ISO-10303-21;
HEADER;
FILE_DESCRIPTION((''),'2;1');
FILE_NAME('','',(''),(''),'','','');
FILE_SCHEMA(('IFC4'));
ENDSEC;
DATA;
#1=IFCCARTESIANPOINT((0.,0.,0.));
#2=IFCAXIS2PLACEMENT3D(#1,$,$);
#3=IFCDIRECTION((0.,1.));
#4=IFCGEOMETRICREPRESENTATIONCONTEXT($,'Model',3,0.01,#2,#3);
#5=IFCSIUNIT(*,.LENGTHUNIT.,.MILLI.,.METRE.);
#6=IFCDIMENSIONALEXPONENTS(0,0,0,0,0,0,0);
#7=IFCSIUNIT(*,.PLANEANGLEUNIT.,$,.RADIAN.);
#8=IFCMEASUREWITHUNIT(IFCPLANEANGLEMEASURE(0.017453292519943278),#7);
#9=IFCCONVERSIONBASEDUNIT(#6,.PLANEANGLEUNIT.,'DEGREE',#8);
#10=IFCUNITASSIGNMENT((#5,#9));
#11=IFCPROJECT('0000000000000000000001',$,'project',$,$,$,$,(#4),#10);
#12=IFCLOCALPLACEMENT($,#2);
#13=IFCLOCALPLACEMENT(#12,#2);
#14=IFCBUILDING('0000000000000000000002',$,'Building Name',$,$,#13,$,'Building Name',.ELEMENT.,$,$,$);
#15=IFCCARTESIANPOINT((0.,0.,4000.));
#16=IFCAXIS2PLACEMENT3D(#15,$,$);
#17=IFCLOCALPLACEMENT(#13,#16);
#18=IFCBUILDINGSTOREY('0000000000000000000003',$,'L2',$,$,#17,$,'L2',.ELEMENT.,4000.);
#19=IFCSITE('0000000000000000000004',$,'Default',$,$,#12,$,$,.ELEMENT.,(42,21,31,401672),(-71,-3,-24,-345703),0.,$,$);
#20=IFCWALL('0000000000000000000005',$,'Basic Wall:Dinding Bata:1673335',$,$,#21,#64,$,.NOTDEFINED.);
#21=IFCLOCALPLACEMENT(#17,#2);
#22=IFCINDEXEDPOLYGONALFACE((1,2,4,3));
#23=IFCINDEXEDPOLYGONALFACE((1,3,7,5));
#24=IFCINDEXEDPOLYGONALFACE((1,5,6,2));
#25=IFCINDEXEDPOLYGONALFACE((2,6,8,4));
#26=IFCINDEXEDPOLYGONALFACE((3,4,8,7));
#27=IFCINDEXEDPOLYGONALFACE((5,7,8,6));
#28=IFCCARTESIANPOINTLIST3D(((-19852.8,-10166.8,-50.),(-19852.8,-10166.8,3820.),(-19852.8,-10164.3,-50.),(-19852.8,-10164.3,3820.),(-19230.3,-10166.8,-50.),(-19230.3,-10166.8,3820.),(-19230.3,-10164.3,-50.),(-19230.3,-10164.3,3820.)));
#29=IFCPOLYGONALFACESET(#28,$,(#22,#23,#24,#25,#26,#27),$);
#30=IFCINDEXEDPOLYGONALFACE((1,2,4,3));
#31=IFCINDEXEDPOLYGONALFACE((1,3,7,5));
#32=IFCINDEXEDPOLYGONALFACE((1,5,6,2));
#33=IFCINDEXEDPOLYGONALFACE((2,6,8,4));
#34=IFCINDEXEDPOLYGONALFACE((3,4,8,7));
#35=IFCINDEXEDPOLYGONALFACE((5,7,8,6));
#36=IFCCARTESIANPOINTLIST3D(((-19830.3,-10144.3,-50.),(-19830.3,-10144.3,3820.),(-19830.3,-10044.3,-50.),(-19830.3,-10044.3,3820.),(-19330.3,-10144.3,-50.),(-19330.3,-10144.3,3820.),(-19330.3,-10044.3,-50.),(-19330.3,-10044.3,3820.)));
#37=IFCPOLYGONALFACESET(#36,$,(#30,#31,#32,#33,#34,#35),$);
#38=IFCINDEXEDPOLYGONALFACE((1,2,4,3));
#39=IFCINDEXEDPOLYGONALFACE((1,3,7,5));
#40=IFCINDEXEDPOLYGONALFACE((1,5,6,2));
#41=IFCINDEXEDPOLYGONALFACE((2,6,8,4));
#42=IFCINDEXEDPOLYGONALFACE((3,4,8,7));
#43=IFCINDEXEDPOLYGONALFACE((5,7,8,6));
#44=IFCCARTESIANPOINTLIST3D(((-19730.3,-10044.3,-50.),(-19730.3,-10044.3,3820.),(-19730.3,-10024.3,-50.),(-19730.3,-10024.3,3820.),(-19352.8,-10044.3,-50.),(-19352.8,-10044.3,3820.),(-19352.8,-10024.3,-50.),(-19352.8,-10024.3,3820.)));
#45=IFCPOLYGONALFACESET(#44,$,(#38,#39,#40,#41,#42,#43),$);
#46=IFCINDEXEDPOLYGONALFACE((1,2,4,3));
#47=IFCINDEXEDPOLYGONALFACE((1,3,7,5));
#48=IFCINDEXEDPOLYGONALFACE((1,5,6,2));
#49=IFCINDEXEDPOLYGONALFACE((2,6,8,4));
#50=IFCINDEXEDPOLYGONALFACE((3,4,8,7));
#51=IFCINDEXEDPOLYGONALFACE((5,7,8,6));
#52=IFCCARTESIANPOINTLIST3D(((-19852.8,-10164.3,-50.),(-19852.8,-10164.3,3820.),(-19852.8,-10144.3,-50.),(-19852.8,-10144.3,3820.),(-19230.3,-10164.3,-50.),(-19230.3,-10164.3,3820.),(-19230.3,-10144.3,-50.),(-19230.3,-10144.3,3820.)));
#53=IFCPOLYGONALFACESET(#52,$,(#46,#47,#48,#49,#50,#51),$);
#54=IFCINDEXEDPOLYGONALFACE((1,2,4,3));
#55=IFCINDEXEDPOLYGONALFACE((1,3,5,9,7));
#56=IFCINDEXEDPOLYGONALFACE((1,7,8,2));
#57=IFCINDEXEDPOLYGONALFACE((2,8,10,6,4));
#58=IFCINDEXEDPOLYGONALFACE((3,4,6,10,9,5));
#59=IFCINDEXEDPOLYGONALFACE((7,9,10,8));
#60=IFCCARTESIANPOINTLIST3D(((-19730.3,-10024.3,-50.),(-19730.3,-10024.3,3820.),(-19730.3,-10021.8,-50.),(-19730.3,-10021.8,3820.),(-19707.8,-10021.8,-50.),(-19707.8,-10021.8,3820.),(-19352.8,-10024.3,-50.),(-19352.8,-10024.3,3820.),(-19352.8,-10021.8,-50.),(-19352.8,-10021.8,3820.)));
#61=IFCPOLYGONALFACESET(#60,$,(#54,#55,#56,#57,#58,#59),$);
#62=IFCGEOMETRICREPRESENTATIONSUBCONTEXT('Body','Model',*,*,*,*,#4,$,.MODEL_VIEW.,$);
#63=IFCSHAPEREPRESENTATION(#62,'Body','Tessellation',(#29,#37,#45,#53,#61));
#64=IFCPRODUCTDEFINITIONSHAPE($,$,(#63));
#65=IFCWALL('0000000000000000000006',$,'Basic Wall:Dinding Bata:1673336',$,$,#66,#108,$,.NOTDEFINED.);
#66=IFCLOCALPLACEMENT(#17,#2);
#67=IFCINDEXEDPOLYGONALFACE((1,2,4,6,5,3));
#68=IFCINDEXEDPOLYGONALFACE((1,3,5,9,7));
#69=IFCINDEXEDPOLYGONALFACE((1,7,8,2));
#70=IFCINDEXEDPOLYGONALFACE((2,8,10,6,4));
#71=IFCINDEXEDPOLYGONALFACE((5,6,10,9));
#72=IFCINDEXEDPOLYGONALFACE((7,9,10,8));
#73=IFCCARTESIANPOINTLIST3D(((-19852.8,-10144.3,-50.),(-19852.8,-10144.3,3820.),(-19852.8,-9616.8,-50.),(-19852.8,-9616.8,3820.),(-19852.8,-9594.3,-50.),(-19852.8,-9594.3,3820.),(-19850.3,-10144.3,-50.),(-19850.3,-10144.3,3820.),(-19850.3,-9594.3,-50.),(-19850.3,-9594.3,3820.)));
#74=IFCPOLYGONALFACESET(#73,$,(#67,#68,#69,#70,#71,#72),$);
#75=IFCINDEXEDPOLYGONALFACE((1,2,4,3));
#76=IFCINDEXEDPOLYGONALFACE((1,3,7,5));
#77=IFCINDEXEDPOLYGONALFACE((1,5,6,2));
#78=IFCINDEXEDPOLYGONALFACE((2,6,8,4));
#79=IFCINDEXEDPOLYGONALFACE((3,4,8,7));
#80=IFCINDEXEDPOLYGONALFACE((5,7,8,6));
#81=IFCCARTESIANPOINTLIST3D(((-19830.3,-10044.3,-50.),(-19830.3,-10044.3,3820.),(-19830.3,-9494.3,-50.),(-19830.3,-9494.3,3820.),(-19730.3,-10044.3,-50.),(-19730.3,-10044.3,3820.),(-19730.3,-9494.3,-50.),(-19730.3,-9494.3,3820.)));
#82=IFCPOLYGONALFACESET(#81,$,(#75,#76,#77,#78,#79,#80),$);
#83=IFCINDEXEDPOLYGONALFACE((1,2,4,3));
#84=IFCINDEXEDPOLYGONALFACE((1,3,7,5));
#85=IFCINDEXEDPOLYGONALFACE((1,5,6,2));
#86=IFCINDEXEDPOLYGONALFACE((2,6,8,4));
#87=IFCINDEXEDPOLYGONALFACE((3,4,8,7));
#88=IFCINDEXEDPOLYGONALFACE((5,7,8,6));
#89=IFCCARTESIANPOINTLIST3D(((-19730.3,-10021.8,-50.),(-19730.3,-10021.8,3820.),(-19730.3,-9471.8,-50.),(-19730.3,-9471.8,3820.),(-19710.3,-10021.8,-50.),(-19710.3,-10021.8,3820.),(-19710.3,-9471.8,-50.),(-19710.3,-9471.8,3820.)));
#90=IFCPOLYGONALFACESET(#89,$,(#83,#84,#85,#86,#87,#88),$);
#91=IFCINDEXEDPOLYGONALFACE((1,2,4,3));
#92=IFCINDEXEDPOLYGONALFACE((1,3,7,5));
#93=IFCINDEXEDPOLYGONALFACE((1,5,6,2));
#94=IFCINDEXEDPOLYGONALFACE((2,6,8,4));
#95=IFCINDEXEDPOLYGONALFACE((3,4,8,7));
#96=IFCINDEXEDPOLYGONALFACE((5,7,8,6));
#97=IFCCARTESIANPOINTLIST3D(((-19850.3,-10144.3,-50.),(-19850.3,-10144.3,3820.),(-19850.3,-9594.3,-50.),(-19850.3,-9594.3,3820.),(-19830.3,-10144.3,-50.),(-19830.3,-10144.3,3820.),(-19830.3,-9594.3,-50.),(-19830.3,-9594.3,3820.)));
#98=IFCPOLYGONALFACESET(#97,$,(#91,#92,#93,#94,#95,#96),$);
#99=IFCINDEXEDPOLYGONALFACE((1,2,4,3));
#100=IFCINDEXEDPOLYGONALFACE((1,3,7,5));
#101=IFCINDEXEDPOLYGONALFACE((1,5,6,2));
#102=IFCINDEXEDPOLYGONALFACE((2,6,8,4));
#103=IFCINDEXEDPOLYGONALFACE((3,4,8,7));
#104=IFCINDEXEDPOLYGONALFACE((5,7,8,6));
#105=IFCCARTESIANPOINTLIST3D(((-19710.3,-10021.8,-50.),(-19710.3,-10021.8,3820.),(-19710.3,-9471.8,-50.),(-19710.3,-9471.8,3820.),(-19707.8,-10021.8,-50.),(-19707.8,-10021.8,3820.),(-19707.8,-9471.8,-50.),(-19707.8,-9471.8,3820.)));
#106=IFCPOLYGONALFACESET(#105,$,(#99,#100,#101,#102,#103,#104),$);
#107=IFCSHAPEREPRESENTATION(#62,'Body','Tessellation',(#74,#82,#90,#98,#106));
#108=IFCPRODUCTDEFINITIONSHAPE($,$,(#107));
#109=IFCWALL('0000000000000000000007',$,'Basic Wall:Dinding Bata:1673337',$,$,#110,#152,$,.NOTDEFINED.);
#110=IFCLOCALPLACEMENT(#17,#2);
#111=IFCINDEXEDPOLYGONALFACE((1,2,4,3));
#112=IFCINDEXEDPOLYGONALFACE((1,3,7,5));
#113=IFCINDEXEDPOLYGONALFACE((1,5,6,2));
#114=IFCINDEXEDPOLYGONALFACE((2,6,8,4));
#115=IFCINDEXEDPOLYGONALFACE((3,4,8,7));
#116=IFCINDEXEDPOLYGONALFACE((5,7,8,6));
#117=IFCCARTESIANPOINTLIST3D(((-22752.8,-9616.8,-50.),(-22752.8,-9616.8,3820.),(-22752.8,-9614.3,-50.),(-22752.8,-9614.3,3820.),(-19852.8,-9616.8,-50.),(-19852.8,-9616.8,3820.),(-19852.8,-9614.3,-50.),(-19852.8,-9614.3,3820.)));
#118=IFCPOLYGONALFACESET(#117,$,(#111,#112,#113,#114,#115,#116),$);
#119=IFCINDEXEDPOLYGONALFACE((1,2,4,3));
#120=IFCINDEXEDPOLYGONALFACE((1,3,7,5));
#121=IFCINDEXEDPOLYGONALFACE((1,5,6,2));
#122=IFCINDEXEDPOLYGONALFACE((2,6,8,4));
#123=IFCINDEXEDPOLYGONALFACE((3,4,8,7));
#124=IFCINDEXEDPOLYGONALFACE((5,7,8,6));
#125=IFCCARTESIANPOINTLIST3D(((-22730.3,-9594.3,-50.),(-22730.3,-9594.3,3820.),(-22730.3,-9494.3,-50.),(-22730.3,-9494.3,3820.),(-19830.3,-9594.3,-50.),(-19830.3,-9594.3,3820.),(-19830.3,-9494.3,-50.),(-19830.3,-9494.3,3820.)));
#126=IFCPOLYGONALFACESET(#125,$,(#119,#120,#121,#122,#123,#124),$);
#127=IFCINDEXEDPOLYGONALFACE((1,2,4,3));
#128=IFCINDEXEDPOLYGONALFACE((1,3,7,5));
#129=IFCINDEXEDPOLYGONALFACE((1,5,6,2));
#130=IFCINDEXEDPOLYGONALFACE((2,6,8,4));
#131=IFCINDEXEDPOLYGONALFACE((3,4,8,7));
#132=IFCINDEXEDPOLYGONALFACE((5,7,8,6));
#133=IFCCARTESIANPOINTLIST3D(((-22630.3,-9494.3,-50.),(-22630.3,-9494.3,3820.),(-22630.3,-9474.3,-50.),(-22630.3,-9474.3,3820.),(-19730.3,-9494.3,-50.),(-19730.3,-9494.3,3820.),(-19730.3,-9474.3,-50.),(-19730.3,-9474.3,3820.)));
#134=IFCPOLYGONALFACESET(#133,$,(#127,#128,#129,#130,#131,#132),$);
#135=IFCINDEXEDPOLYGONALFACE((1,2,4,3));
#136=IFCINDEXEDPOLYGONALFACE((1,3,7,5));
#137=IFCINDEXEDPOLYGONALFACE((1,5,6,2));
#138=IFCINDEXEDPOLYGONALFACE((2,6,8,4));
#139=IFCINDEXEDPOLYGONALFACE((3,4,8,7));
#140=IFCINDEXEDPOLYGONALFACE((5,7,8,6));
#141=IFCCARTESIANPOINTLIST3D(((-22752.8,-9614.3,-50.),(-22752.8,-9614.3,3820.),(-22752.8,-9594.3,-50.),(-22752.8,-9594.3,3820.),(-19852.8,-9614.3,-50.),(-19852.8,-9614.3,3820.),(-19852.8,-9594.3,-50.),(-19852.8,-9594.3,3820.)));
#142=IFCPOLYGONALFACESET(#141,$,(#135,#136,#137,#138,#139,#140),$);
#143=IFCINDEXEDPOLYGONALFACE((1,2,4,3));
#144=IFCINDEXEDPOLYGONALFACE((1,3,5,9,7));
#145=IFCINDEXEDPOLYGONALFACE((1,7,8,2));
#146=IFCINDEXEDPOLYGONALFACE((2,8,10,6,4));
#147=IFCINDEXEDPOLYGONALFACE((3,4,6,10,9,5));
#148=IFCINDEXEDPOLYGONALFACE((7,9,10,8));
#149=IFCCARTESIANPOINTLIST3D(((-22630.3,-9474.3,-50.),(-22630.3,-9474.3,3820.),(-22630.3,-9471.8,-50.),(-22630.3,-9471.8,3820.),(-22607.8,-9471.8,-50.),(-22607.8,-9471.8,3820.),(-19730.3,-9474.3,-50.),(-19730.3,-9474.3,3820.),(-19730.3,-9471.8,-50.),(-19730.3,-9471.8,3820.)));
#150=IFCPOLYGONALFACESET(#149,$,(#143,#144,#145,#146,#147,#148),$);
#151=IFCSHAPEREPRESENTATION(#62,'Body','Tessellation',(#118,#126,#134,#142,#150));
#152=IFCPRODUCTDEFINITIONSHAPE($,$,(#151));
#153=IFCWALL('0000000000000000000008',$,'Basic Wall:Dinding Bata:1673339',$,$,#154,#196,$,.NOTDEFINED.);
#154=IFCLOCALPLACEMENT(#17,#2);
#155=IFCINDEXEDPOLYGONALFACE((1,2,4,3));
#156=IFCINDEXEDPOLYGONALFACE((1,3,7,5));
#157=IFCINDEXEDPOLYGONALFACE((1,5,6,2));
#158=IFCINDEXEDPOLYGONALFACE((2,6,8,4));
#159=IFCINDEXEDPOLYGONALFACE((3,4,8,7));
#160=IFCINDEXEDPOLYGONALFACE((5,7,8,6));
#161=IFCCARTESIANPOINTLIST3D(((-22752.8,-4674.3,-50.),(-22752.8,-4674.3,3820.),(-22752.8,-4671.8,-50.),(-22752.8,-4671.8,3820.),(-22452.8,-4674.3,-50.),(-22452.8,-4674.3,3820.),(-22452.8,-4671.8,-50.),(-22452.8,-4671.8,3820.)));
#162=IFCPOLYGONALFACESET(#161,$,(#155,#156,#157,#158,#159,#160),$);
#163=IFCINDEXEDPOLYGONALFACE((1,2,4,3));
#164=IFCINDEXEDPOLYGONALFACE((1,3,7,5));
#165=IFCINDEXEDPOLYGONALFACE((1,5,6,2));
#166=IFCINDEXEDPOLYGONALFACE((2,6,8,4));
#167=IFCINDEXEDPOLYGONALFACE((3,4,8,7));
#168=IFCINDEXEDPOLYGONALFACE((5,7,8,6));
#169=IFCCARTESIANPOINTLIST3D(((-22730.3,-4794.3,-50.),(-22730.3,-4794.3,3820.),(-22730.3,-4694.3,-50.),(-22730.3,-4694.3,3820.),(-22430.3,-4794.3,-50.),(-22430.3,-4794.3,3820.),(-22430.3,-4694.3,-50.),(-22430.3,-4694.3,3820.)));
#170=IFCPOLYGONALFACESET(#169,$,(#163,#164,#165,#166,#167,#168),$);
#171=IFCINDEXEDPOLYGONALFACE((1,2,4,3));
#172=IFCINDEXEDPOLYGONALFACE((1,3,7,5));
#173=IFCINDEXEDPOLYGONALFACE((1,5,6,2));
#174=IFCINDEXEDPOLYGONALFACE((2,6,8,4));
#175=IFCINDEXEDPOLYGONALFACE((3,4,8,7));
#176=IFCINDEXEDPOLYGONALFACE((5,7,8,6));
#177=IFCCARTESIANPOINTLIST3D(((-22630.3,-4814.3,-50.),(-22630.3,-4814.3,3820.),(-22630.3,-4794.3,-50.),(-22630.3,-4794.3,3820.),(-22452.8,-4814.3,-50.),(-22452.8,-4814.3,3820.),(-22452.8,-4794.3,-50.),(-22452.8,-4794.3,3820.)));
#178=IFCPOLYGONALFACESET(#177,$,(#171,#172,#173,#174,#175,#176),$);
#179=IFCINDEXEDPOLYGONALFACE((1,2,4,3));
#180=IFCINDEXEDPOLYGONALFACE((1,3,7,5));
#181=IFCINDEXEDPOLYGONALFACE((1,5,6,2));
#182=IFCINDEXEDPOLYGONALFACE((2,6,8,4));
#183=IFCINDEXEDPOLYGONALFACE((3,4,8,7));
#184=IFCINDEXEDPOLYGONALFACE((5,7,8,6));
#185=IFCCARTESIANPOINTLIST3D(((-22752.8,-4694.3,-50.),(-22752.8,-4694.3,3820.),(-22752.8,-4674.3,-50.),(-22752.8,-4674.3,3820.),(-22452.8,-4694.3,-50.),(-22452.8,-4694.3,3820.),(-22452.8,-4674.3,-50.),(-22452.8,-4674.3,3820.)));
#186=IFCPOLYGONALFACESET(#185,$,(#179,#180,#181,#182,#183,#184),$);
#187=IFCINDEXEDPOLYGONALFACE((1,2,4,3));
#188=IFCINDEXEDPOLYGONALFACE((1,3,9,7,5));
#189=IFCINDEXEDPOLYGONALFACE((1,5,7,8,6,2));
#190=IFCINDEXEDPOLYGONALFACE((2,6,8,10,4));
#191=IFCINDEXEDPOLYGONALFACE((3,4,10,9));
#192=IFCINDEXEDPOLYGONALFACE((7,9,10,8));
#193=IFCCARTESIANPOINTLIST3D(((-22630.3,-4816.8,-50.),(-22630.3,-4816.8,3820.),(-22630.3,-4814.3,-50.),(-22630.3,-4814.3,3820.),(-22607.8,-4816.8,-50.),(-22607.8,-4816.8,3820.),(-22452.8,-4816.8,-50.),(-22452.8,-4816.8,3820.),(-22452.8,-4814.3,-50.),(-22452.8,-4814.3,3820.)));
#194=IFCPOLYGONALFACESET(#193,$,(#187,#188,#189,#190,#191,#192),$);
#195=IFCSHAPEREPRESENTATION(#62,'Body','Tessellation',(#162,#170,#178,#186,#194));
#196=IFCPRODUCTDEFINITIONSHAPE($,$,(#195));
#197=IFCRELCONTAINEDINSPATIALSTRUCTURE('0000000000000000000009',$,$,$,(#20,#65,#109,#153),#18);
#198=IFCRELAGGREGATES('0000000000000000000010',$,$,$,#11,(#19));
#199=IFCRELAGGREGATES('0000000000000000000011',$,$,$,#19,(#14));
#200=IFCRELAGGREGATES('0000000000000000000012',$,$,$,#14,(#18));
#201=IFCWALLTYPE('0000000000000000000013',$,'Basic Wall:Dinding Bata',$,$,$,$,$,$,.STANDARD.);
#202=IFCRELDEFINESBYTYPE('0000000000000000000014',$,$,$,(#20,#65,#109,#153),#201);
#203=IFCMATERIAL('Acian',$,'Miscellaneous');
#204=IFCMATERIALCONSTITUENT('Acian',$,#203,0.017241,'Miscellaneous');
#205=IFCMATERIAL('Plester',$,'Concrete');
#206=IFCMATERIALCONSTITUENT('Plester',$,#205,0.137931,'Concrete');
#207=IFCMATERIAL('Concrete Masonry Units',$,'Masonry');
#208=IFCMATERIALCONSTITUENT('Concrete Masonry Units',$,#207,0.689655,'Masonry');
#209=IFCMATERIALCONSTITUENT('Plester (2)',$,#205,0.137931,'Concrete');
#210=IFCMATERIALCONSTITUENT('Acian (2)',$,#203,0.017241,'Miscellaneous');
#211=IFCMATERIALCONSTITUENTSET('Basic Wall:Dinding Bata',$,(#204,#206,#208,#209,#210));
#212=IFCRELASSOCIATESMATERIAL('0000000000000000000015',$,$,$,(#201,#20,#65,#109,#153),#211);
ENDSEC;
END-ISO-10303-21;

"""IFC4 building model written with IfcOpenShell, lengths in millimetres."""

from ifc_helpers import new_model, entity, si_unit, converted_unit, direction, frame, origin, place, context, subcontext, project, spatial, indexed_curve, outline, extrude, material, constituent, constituent_set, type_object, element, save


model = new_model("IFC4")

# Units and contexts
model_context = context("Model", 3, precision=0.01, world=origin(), true_north=direction((0.0, 1.0)))
body_context = subcontext(model_context, "Body", "Model", "MODEL_VIEW")
ifc_project = project(units=[si_unit("LENGTHUNIT", "METRE", prefix="MILLI"), converted_unit("PLANEANGLEUNIT", "DEGREE", entity("IfcPlaneAngleMeasure", 0.017453292519943278), si_unit("PLANEANGLEUNIT", "RADIAN"), dimensions=[0, 0, 0, 0, 0, 0, 0])], contexts=[model_context])

# Site, building, storey
site_placement = place(None, origin())
site = spatial("IfcSite", under=ifc_project, at=site_placement, Name="Default", CompositionType="ELEMENT", RefLatitude=(42, 21, 31, 401672), RefLongitude=(-71, -3, -24, -345703), RefElevation=0.0)
building_placement = place(site_placement, origin())
building = spatial("IfcBuilding", under=site, at=building_placement, Name="Building Name", LongName="Building Name", CompositionType="ELEMENT")
storey_placement = place(building_placement, frame((0.0, 0.0, 4000.0)))
storey = spatial("IfcBuildingStorey", under=building, at=storey_placement, Name="L2", LongName="L2", CompositionType="ELEMENT", Elevation=4000.0)

# Walls
ifc_material_1 = material(Name="Acian", Category="Miscellaneous")
ifc_constituent_1 = constituent(ifc_material_1, Name="Acian", Category="Miscellaneous", fraction=0.017241)
ifc_material_2 = material(Name="Plester", Category="Concrete")
ifc_constituent_2 = constituent(ifc_material_2, Name="Plester", Category="Concrete", fraction=0.137931)
ifc_material_3 = material(Name="Concrete Masonry Units", Category="Masonry")
ifc_constituent_3 = constituent(ifc_material_3, Name="Concrete Masonry Units", Category="Masonry", fraction=0.689655)
ifc_constituent_4 = constituent(ifc_material_2, Name="Plester (2)", Category="Concrete", fraction=0.137931)
ifc_constituent_5 = constituent(ifc_material_1, Name="Acian (2)", Category="Miscellaneous", fraction=0.017241)
ifc_constituent_set = constituent_set(constituents=[ifc_constituent_1, ifc_constituent_2, ifc_constituent_3, ifc_constituent_4, ifc_constituent_5], Name="Basic Wall:Dinding Bata")
wall_type = type_object("IfcWallType", Name="Basic Wall:Dinding Bata", PredefinedType="STANDARD", material=ifc_constituent_set)
wall_1_placement = place(storey_placement, frame((-19352.8, -10094.3, -50.0), z_axis=(0.0, 0.0, 1.0), x_axis=(-1.0, 0.0, 0.0)))
element("IfcWall", 1, at=wall_1_placement, inside=storey, type_object=wall_type, material=ifc_constituent_set, Name="Basic Wall:Dinding Bata:1673335", PredefinedType="NOTDEFINED", context=body_context, shape_type="SweptSolid", body=[
    extrude(outline(indexed_curve([(-1.3, -311.2), (1.2, -311.2), (1.3, 311.2), (-1.2, 311.2), (-1.3, -311.2)], self_intersect=False)), frame((188.7, 71.2, 0.0), z_axis=(0.0, 0.0, 1.0), x_axis=(0.0, -1.0, 0.0)), (0.0, 0.0, 1.0), 3870.0),
    extrude(outline(indexed_curve([(-250.0, -50.0), (250.0, -50.0), (250.0, 50.0), (-250.0, 50.0), (-250.0, -50.0)], self_intersect=False)), frame((227.5, 0.0, 0.0)), (0.0, 0.0, 1.0), 3870.0),
    extrude(outline(indexed_curve([(-188.7, -10.0), (188.7, -10.0), (188.7, 10.0), (-188.7, 10.0), (-188.7, -10.0)], self_intersect=False)), frame((188.7, -60.0, 0.0)), (0.0, 0.0, 1.0), 3870.0),
    extrude(outline(indexed_curve([(-311.2, -10.0), (311.2, -10.0), (311.2, 10.0), (-311.2, 10.0), (-311.2, -10.0)], self_intersect=False)), frame((188.7, 60.0, 0.0)), (0.0, 0.0, 1.0), 3870.0),
    extrude(outline(indexed_curve([(133.0, -1.0), (155.5, -1.0), (155.5, 1.5), (-222.0, 1.5), (-222.0, -1.0), (133.0, -1.0)], self_intersect=False)), frame((222.0, -71.5, 0.0)), (0.0, 0.0, 1.0), 3870.0),
])
wall_2_placement = place(storey_placement, frame((-19780.3, -10021.8, -50.0), z_axis=(0.0, 0.0, 1.0), x_axis=(0.0, 1.0, 0.0)))
element("IfcWall", 2, at=wall_2_placement, inside=storey, type_object=wall_type, material=ifc_constituent_set, Name="Basic Wall:Dinding Bata:1673336", PredefinedType="NOTDEFINED", context=body_context, shape_type="SweptSolid", body=[
    extrude(outline(indexed_curve([(-202.0, -1.0), (325.5, -1.0), (325.5, 1.5), (-224.5, 1.5), (-224.5, -1.0), (-202.0, -1.0)], self_intersect=False)), frame((203.0, 71.5, 0.0), z_axis=(0.0, 0.0, 1.0), x_axis=(-1.0, 0.0, 0.0)), (0.0, 0.0, 1.0), 3870.0),
    extrude(outline(indexed_curve([(-275.0, -50.0), (275.0, -50.0), (275.0, 50.0), (-275.0, 50.0), (-275.0, -50.0)], self_intersect=False)), frame((252.5, 0.0, 0.0)), (0.0, 0.0, 1.0), 3870.0),
    extrude(outline(indexed_curve([(-275.0, -10.0), (275.0, -10.0), (275.0, 10.0), (-275.0, 10.0), (-275.0, -10.0)], self_intersect=False)), frame((275.0, -60.0, 0.0)), (0.0, 0.0, 1.0), 3870.0),
    extrude(outline(indexed_curve([(-275.0, -10.0), (275.0, -10.0), (275.0, 10.0), (-275.0, 10.0), (-275.0, -10.0)], self_intersect=False)), frame((152.5, 60.0, 0.0)), (0.0, 0.0, 1.0), 3870.0),
    extrude(outline(indexed_curve([(-1.2, -275.0), (1.2, -275.0), (1.2, 275.0), (-1.2, 275.0), (-1.2, -275.0)], self_intersect=False)), frame((275.0, -71.3, 0.0), z_axis=(0.0, 0.0, 1.0), x_axis=(0.0, 1.0, 0.0)), (0.0, 0.0, 1.0), 3870.0),
])
wall_3_placement = place(storey_placement, frame((-19852.8, -9544.3, -50.0), z_axis=(0.0, 0.0, 1.0), x_axis=(-1.0, 0.0, 0.0)))
element("IfcWall", 3, at=wall_3_placement, inside=storey, type_object=wall_type, material=ifc_constituent_set, Name="Basic Wall:Dinding Bata:1673337", PredefinedType="NOTDEFINED", context=body_context, shape_type="SweptSolid", body=[
    extrude(outline(indexed_curve([(-1.3, -1450.0), (1.2, -1450.0), (1.3, 1450.0), (-1.2, 1450.0), (-1.3, -1450.0)], self_intersect=False)), frame((1450.0, 71.3, 0.0), z_axis=(0.0, 0.0, 1.0), x_axis=(0.0, -1.0, 0.0)), (0.0, 0.0, 1.0), 3870.0),
    extrude(outline(indexed_curve([(-1450.0, -50.0), (1450.0, -50.0), (1450.0, 50.0), (-1450.0, 50.0), (-1450.0, -50.0)], self_intersect=False)), frame((1427.5, 0.0, 0.0)), (0.0, 0.0, 1.0), 3870.0),
    extrude(outline(indexed_curve([(-1450.0, -10.0), (1450.0, -10.0), (1450.0, 10.0), (-1450.0, 10.0), (-1450.0, -10.0)], self_intersect=False)), frame((1327.5, -60.0, 0.0)), (0.0, 0.0, 1.0), 3870.0),
    extrude(outline(indexed_curve([(-1450.0, -10.0), (1450.0, -10.0), (1450.0, 10.0), (-1450.0, 10.0), (-1450.0, -10.0)], self_intersect=False)), frame((1450.0, 60.0, 0.0)), (0.0, 0.0, 1.0), 3870.0),
    extrude(outline(indexed_curve([(1142.0, -1.0), (1164.5, -1.0), (1164.5, 1.5), (-1735.5, 1.5), (-1735.5, -1.0), (1142.0, -1.0)], self_intersect=False)), frame((1613.0, -71.5, 0.0)), (0.0, 0.0, 1.0), 3870.0),
])
wall_4_placement = place(storey_placement, frame((-22752.8, -4744.3, -50.0)))
element("IfcWall", 4, at=wall_4_placement, inside=storey, type_object=wall_type, material=ifc_constituent_set, Name="Basic Wall:Dinding Bata:1673339", PredefinedType="NOTDEFINED", context=body_context, shape_type="SweptSolid", body=[
    extrude(outline(indexed_curve([(-1.3, -150.0), (1.2, -150.0), (1.3, 150.0), (-1.2, 150.0), (-1.3, -150.0)], self_intersect=False)), frame((150.0, 71.3, 0.0), z_axis=(0.0, 0.0, 1.0), x_axis=(0.0, -1.0, 0.0)), (0.0, 0.0, 1.0), 3870.0),
    extrude(outline(indexed_curve([(-150.0, -50.0), (150.0, -50.0), (150.0, 50.0), (-150.0, 50.0), (-150.0, -50.0)], self_intersect=False)), frame((172.5, 0.0, 0.0)), (0.0, 0.0, 1.0), 3870.0),
    extrude(outline(indexed_curve([(-88.7, -10.0), (88.7, -10.0), (88.7, 10.0), (-88.7, 10.0), (-88.7, -10.0)], self_intersect=False)), frame((211.2, -60.0, 0.0)), (0.0, 0.0, 1.0), 3870.0),
    extrude(outline(indexed_curve([(-150.0, -10.0), (150.0, -10.0), (150.0, 10.0), (-150.0, 10.0), (-150.0, -10.0)], self_intersect=False)), frame((150.0, 60.0, 0.0)), (0.0, 0.0, 1.0), 3870.0),
    extrude(outline(indexed_curve([(-53.0, -1.0), (102.0, -1.0), (102.0, 1.5), (-75.5, 1.5), (-75.5, -1.0), (-53.0, -1.0)], self_intersect=False)), frame((198.0, -71.5, 0.0)), (0.0, 0.0, 1.0), 3870.0),
])

save(model, "model.ifc")
